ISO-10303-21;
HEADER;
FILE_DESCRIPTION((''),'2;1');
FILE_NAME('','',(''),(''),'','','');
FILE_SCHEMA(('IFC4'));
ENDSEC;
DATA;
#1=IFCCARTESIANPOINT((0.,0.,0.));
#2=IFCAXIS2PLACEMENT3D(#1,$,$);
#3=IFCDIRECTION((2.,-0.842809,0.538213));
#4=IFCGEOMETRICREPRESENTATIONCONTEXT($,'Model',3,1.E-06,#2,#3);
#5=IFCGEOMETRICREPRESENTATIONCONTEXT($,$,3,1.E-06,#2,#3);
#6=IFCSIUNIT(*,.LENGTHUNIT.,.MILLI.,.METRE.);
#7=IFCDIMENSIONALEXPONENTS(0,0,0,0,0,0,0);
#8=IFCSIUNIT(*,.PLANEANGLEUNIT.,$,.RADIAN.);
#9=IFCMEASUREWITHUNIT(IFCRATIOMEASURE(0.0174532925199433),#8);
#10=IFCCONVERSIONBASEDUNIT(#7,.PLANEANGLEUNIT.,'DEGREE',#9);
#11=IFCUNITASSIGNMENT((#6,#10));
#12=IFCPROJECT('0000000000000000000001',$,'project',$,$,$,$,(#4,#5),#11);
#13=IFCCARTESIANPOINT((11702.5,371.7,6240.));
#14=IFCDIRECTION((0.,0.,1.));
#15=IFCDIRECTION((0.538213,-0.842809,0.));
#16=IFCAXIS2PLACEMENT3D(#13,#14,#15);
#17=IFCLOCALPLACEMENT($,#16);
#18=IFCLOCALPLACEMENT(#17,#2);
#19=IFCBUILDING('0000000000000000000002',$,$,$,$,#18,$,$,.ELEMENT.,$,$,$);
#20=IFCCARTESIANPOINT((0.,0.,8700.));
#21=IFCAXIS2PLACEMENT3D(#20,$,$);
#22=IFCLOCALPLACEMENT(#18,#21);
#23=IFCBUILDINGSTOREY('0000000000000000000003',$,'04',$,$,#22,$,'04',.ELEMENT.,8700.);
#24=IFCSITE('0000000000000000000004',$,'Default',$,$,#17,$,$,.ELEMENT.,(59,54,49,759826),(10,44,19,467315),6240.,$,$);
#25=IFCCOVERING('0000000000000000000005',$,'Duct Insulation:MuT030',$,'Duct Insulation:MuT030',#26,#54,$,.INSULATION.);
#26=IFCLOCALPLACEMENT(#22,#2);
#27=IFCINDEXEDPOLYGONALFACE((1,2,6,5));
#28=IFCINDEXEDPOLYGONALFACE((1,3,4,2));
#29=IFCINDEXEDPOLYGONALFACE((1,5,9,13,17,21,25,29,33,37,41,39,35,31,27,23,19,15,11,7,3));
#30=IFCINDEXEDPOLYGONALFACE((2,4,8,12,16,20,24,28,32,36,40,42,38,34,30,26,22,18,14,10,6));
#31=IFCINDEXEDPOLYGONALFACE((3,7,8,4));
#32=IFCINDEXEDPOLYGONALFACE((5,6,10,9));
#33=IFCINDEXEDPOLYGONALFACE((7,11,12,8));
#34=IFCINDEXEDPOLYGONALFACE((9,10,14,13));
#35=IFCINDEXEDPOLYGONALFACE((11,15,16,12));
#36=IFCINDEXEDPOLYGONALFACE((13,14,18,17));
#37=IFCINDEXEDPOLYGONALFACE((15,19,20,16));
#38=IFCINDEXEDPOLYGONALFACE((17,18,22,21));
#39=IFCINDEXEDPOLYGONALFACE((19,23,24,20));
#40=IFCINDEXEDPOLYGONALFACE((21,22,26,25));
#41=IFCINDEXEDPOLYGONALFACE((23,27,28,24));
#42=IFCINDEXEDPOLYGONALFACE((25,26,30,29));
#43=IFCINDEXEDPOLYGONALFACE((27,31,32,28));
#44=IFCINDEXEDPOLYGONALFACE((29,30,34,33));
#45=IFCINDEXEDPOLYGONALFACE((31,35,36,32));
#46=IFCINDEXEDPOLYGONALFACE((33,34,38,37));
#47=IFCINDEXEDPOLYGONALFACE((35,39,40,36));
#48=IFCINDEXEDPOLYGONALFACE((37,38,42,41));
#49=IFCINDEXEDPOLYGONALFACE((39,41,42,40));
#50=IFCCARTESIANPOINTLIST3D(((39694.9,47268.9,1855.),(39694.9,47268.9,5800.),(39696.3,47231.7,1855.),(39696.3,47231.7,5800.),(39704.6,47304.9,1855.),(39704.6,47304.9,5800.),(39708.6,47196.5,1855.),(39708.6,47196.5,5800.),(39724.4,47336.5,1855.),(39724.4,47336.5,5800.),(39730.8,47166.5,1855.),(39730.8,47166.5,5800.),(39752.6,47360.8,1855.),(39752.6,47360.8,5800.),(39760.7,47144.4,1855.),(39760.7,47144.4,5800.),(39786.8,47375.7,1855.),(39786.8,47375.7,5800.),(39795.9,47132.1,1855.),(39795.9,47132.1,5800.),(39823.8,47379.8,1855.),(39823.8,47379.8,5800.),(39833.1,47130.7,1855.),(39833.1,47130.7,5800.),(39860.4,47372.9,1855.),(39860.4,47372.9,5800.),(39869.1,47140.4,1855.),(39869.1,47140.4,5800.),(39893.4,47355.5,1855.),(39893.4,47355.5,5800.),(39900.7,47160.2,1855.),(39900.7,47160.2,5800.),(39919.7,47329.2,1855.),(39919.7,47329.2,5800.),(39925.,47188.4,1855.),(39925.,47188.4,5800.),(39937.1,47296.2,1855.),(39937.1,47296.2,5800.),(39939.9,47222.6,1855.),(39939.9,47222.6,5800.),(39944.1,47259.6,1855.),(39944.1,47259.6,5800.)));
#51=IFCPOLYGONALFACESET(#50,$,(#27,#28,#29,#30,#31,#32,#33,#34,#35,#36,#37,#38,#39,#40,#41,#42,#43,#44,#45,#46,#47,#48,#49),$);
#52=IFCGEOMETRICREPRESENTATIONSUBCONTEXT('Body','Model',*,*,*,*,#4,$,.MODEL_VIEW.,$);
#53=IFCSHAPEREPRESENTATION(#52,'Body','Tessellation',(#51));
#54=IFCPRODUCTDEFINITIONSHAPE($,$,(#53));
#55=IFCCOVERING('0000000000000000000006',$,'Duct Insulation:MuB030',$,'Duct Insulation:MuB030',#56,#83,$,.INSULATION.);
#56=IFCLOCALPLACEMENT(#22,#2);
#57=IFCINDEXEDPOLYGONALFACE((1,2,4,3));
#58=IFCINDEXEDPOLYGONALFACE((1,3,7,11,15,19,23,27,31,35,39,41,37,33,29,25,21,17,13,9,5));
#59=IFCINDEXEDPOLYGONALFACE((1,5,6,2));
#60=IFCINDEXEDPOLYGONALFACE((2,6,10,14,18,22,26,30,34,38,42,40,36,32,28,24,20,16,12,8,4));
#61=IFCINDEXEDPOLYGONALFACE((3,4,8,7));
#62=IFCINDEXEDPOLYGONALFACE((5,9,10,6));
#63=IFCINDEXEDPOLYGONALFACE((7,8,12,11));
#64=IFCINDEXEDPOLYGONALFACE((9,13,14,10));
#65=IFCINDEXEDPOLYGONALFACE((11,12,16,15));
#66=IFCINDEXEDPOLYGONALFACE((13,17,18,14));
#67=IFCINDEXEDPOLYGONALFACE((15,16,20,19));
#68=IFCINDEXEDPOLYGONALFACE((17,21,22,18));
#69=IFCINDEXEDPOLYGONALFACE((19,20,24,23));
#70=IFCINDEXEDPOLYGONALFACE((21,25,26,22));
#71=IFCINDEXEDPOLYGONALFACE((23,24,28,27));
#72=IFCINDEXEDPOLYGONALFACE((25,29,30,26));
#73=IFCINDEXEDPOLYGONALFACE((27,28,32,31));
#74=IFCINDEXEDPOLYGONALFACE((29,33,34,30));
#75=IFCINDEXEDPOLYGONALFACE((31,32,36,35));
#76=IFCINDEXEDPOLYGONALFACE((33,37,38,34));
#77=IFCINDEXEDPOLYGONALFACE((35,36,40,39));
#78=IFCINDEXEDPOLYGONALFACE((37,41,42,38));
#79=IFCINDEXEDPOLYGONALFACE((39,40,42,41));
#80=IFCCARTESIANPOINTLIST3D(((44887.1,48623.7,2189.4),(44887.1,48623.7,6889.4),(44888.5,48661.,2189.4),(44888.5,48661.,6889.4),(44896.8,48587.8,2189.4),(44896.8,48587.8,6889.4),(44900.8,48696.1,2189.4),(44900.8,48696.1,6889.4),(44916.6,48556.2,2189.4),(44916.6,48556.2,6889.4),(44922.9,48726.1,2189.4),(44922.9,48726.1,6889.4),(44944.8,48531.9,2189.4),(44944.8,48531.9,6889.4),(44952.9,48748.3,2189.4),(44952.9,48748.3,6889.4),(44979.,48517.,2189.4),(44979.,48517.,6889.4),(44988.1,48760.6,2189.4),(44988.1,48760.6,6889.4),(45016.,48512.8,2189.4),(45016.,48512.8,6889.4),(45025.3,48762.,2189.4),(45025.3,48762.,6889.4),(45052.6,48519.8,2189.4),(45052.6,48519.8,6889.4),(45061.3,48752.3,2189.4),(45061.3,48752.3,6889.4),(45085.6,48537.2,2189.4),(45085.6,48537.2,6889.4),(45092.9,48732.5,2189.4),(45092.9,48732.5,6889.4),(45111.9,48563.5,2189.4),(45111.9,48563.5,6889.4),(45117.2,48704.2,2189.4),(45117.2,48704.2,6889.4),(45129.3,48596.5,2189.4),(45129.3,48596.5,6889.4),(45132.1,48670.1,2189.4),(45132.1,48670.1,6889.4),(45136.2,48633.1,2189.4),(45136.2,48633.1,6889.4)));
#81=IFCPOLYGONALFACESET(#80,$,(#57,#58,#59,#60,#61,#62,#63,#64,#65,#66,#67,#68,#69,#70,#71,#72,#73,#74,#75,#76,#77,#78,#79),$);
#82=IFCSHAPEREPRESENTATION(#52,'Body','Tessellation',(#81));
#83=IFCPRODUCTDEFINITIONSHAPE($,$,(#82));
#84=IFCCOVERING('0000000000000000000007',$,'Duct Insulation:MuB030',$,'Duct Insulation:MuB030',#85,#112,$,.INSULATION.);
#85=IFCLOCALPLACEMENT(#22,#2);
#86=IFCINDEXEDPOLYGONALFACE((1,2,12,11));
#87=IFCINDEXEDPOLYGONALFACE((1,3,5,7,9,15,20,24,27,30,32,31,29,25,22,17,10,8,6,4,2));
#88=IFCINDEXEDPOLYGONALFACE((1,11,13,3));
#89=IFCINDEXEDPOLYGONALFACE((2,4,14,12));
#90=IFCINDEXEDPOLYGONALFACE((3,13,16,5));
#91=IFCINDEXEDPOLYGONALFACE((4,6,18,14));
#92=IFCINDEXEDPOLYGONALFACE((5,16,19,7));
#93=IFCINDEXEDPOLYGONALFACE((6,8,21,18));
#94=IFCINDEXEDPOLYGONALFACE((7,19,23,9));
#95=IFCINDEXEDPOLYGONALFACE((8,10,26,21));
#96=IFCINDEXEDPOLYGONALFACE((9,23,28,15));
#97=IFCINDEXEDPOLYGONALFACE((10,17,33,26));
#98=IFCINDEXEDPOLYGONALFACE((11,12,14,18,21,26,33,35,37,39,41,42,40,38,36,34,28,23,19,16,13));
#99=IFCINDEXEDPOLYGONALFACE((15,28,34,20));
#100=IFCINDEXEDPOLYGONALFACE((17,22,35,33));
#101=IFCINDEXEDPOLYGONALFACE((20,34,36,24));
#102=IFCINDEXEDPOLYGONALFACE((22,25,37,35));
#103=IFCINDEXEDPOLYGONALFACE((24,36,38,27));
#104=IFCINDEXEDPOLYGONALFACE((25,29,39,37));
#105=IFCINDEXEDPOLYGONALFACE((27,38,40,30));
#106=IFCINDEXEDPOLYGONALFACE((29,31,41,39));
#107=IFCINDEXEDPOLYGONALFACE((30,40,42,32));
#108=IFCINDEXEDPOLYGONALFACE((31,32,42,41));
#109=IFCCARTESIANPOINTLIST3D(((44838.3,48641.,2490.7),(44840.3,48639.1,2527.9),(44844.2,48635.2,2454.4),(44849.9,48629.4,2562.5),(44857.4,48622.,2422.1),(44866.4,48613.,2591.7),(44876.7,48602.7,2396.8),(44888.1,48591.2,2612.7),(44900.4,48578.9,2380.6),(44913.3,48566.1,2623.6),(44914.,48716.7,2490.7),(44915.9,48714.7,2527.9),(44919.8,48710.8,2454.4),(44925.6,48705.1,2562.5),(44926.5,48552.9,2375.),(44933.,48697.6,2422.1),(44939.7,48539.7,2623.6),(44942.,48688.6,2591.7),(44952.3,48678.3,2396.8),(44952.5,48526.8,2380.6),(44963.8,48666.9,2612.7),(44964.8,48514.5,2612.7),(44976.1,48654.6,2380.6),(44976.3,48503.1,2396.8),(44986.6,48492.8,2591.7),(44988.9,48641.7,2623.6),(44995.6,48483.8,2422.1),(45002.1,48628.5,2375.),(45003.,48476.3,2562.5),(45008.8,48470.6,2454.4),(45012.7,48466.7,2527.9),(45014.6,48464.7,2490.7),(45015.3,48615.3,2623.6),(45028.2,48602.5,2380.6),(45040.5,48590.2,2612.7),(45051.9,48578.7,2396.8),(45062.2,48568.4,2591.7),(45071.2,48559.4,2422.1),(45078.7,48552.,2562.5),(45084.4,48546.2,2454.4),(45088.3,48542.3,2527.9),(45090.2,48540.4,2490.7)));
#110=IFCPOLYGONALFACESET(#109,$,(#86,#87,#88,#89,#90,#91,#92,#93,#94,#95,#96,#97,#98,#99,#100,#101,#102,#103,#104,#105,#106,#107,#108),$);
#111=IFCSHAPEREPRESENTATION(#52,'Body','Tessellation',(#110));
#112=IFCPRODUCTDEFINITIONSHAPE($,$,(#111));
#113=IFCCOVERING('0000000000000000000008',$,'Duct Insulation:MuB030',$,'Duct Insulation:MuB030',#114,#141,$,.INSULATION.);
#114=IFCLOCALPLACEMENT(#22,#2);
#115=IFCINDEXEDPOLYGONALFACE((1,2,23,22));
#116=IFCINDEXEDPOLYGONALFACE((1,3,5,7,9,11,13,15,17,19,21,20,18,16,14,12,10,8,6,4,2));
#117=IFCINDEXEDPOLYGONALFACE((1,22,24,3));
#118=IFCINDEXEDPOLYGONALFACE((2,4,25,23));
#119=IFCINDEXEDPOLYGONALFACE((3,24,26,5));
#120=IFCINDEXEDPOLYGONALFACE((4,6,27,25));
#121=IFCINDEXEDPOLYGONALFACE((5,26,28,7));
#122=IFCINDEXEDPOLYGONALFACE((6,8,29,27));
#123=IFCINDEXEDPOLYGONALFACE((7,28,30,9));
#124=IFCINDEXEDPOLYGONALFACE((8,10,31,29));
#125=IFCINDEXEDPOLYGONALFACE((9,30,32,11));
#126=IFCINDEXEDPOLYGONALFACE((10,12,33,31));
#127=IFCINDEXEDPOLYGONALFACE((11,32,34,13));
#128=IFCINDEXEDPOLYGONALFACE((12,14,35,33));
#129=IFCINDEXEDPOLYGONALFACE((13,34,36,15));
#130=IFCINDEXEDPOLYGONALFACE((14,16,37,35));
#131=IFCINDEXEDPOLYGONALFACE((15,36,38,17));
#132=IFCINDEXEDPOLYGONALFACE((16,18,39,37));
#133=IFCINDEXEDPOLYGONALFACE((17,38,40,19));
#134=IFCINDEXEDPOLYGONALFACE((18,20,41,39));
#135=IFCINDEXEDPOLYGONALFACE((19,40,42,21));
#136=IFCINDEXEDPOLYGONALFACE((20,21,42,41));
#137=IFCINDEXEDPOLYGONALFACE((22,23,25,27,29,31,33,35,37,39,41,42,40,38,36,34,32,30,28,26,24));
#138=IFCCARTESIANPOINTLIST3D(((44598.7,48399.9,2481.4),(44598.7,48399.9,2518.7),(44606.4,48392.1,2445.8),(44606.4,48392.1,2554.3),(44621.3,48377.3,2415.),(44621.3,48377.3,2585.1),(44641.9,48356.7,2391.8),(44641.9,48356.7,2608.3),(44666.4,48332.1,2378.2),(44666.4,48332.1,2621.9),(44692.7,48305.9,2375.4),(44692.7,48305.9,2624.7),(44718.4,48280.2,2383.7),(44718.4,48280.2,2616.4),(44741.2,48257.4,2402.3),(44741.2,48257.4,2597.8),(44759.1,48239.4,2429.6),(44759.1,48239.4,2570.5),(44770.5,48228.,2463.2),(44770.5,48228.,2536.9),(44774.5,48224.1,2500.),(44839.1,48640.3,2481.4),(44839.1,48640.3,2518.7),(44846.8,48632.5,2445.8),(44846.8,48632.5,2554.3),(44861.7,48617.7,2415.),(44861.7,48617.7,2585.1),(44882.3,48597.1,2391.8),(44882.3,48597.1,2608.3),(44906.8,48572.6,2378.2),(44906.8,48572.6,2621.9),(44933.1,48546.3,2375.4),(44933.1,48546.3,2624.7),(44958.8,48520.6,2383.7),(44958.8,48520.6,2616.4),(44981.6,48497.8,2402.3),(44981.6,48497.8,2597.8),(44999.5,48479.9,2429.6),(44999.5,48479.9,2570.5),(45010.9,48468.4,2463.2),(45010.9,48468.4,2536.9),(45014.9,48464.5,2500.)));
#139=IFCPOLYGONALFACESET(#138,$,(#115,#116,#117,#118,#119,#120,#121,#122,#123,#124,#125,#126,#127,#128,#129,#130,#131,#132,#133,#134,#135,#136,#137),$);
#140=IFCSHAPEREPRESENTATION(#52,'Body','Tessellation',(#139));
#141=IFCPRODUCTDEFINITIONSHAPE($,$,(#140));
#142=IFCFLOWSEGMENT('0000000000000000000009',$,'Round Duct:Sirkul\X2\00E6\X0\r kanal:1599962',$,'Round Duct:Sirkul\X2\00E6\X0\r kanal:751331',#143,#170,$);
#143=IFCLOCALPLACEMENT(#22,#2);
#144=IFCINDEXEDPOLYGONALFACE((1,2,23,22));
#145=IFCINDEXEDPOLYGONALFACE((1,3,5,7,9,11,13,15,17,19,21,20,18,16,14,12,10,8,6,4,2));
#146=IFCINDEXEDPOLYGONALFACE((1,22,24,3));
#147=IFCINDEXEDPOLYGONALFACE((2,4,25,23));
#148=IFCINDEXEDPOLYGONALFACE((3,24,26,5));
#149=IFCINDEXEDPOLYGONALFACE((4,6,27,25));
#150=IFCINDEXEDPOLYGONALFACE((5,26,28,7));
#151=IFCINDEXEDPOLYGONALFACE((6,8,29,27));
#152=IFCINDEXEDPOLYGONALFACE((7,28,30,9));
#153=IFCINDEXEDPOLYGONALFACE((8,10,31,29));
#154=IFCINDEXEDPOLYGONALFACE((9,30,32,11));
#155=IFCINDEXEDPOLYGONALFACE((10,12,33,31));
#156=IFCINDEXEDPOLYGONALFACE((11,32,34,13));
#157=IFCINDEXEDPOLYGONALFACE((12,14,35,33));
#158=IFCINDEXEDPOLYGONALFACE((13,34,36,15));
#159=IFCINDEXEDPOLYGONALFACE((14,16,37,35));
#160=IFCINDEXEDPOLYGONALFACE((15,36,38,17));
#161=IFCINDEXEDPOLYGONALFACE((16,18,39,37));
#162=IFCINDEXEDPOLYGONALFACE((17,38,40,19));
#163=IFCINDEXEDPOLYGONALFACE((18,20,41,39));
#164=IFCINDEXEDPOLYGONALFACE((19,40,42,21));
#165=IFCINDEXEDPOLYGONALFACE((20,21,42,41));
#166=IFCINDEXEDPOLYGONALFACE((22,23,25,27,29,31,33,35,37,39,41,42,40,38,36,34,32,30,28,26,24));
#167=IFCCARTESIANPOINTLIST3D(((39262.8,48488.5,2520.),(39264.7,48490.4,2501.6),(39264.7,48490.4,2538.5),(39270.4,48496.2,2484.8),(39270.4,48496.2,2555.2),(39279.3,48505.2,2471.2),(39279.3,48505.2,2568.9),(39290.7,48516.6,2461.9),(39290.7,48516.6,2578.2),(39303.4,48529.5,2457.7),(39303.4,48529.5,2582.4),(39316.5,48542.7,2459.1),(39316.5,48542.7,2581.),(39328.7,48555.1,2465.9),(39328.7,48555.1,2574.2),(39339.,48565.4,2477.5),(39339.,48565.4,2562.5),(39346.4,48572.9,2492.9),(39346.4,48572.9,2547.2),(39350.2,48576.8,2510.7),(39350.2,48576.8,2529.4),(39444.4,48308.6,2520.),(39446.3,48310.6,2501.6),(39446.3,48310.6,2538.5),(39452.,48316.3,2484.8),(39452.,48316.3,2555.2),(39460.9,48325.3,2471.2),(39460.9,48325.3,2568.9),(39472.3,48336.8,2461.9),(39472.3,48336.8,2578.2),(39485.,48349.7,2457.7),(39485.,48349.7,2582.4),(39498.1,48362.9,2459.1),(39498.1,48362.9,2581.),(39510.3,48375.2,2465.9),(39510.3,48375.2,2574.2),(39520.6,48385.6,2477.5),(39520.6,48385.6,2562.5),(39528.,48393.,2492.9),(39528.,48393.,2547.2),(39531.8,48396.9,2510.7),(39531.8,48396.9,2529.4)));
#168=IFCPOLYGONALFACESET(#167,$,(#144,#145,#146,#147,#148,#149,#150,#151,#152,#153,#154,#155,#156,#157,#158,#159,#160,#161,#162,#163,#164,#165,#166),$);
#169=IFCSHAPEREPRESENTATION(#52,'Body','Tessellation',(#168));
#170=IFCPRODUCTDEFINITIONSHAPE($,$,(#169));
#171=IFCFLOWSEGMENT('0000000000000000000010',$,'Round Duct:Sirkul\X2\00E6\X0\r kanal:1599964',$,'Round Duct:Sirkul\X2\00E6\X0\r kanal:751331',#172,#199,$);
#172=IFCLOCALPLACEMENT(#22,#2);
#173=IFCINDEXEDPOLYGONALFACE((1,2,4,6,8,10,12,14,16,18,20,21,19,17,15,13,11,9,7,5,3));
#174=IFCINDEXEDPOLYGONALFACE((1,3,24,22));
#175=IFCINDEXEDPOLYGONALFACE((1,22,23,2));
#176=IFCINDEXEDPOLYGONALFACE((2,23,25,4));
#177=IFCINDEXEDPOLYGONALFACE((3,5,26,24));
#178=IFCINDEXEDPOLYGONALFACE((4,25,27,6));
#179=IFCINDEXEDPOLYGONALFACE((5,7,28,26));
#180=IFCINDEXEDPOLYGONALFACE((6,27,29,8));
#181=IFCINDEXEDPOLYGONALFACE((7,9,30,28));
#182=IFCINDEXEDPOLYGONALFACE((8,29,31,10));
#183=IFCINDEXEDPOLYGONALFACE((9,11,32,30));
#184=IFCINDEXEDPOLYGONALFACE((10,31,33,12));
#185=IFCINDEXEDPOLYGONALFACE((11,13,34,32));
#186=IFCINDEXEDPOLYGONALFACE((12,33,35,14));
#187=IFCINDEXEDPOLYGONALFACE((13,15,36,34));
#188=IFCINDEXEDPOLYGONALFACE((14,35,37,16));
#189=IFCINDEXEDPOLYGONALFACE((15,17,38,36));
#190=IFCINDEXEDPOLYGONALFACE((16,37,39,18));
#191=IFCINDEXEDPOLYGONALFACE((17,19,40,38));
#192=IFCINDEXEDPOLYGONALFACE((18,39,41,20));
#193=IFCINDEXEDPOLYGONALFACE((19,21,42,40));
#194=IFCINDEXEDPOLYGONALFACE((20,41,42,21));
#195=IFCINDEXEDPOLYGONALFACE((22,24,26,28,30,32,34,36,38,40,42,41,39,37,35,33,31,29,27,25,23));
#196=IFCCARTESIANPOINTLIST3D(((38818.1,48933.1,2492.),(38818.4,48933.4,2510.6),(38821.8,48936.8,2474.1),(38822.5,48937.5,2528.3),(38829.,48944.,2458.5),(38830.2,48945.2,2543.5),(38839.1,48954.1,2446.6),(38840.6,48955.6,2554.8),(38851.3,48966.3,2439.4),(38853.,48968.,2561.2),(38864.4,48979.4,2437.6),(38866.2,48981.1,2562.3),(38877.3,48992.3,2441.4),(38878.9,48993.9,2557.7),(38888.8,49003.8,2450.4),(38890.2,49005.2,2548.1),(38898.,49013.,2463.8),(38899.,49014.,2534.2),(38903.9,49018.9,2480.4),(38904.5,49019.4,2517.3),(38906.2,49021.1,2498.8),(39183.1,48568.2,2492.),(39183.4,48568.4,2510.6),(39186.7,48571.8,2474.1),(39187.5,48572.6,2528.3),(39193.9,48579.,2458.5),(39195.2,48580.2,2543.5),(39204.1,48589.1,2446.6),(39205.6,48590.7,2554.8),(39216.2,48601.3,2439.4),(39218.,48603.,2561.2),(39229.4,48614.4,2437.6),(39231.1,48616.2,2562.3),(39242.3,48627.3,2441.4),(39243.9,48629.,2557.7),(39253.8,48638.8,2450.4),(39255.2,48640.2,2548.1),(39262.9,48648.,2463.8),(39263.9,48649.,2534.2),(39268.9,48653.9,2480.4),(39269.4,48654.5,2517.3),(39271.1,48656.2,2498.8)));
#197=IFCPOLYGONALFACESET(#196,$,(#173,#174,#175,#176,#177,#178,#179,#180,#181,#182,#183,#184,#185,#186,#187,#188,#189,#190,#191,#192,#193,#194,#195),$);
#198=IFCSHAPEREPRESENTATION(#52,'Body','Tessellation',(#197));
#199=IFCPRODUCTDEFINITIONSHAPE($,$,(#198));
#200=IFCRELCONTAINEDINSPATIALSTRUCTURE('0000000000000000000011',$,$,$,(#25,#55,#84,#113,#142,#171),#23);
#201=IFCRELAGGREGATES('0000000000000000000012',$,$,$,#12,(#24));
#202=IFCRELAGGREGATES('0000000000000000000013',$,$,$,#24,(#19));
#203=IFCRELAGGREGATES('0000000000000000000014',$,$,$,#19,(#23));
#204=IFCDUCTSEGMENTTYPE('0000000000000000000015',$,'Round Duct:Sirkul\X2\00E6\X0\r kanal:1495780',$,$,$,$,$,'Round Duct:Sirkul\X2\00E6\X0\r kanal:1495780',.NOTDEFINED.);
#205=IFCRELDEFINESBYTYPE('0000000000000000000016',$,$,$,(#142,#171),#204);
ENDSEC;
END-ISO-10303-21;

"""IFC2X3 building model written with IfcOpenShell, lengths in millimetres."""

from ifc_helpers import new_model, entity, si_unit, converted_unit, direction, frame, frame_2d, origin, origin_2d_with_axis, place, context, subcontext, project, spatial, circle, extrude, type_object, element, save


model = new_model("IFC2X3")

# Units and contexts
model_context = context("Model", 3, precision=1e-06, world=origin(), true_north=direction((2.0, -0.842809, 0.538213)))
context_of_model = context(None, 3, precision=1e-06, world=origin(), true_north=direction((2.0, -0.842809, 0.538213)))
body_context = subcontext(model_context, "Body", "Model", "MODEL_VIEW")
ifc_project = project(units=[si_unit("LENGTHUNIT", "METRE", prefix="MILLI"), converted_unit("PLANEANGLEUNIT", "DEGREE", entity("IfcRatioMeasure", 0.0174532925199433), si_unit("PLANEANGLEUNIT", "RADIAN"), dimensions=[0, 0, 0, 0, 0, 0, 0])], contexts=[model_context, context_of_model])

# Site, building, storey
site_placement = place(None, frame((11702.5, 371.7, 6240.0), z_axis=(0.0, 0.0, 1.0), x_axis=(0.538213, -0.842809, 0.0)))
site = spatial("IfcSite", under=ifc_project, at=site_placement, Name="Default", CompositionType="ELEMENT", RefLatitude=(59, 54, 49, 759826), RefLongitude=(10, 44, 19, 467315), RefElevation=6240.0)
building_placement = place(site_placement, origin())
building = spatial("IfcBuilding", under=site, at=building_placement, CompositionType="ELEMENT")
storey_placement = place(building_placement, frame((0.0, 0.0, 8700.0)))
storey = spatial("IfcBuildingStorey", under=building, at=storey_placement, Name="04", LongName="04", CompositionType="ELEMENT", Elevation=8700.0)

# Coverings
covering_1_placement = place(building_placement, frame((0.0, 0.0, 8700.0)))
element("IfcCovering", 1, at=covering_1_placement, inside=storey, Name="Duct Insulation:MuT030", ObjectType="Duct Insulation:MuT030", PredefinedType="INSULATION", context=body_context, shape_type="SweptSolid", body=[
    extrude(circle(Radius=125.0, at=origin_2d_with_axis()), frame((39819.1, 47254.9, 1855.0), z_axis=(0.0, 0.0, 1.0), x_axis=(-0.707107, -0.707107, 0.0)), (0.0, 0.0, 1.0), 3945.0),
])
covering_2_placement = place(building_placement, frame((0.0, 0.0, 8700.0)))
element("IfcCovering", 2, at=covering_2_placement, inside=storey, Name="Duct Insulation:MuB030", ObjectType="Duct Insulation:MuB030", PredefinedType="INSULATION", context=body_context, shape_type="SweptSolid", body=[
    extrude(circle(Radius=125.0, at=frame_2d((0.0, 0.0), x_axis=(1.0, 0.0))), frame((45011.3, 48637.7, 2189.4), z_axis=(0.0, 0.0, 1.0), x_axis=(-0.707107, 0.707107, 0.0)), (0.0, 0.0, 1.0), 4700.0),
])
covering_3_placement = place(building_placement, frame((0.0, 0.0, 8700.0)))
element("IfcCovering", 3, at=covering_3_placement, inside=storey, Name="Duct Insulation:MuB030", ObjectType="Duct Insulation:MuB030", PredefinedType="INSULATION", context=body_context, shape_type="SweptSolid", body=[
    extrude(circle(Radius=125.0, at=origin_2d_with_axis()), frame((44926.5, 48552.9, 2500.0), z_axis=(0.707107, 0.707107, 0.0), x_axis=(0.0, 0.0, -1.0)), (0.0, 0.0, 1.0), 107.0),
])
covering_4_placement = place(building_placement, frame((0.0, 0.0, 8700.0)))
element("IfcCovering", 4, at=covering_4_placement, inside=storey, Name="Duct Insulation:MuB030", ObjectType="Duct Insulation:MuB030", PredefinedType="INSULATION", context=body_context, shape_type="SweptSolid", body=[
    extrude(circle(Radius=125.0, at=frame_2d((0.0, 0.0), x_axis=(1.0, 0.0))), frame((44686.1, 48312.5, 2500.0), z_axis=(0.707107, 0.707107, 0.0), x_axis=(0.707107, -0.707107, 0.0)), (0.0, 0.0, 1.0), 340.0),
])

# Flow segments
duct_segment_type = type_object("IfcDuctSegmentType", Name="Round Duct:Sirkulær kanal:1495780", ElementType="Round Duct:Sirkulær kanal:1495780", PredefinedType="NOTDEFINED")
flow_segment_1_placement = place(storey_placement, origin())
element("IfcFlowSegment", 5, at=flow_segment_1_placement, inside=storey, type_object=duct_segment_type, Name="Round Duct:Sirkulær kanal:1599962", ObjectType="Round Duct:Sirkulær kanal:751331", context=body_context, shape_type="SweptSolid", body=[
    extrude(circle(Radius=62.5, at=origin_2d_with_axis()), frame((39488.3, 48353.0, 2520.0), z_axis=(-0.710554, 0.703643, 0.0), x_axis=(-0.703643, -0.710554, 0.0)), (0.0, 0.0, 1.0), 255.6),
])
flow_segment_2_placement = place(storey_placement, origin())
element("IfcFlowSegment", 6, at=flow_segment_2_placement, inside=storey, type_object=duct_segment_type, Name="Round Duct:Sirkulær kanal:1599964", ObjectType="Round Duct:Sirkulær kanal:751331", context=body_context, shape_type="SweptSolid", body=[
    extrude(circle(Radius=62.5, at=frame_2d((0.0, 0.0), x_axis=(1.0, 0.0))), frame((39226.9, 48612.0, 2500.0), z_axis=(-0.707107, 0.707107, 0.0), x_axis=(0.706963, 0.706963, -0.020154)), (0.0, 0.0, 1.0), 516.1),
])

save(model, "model.ifc")
